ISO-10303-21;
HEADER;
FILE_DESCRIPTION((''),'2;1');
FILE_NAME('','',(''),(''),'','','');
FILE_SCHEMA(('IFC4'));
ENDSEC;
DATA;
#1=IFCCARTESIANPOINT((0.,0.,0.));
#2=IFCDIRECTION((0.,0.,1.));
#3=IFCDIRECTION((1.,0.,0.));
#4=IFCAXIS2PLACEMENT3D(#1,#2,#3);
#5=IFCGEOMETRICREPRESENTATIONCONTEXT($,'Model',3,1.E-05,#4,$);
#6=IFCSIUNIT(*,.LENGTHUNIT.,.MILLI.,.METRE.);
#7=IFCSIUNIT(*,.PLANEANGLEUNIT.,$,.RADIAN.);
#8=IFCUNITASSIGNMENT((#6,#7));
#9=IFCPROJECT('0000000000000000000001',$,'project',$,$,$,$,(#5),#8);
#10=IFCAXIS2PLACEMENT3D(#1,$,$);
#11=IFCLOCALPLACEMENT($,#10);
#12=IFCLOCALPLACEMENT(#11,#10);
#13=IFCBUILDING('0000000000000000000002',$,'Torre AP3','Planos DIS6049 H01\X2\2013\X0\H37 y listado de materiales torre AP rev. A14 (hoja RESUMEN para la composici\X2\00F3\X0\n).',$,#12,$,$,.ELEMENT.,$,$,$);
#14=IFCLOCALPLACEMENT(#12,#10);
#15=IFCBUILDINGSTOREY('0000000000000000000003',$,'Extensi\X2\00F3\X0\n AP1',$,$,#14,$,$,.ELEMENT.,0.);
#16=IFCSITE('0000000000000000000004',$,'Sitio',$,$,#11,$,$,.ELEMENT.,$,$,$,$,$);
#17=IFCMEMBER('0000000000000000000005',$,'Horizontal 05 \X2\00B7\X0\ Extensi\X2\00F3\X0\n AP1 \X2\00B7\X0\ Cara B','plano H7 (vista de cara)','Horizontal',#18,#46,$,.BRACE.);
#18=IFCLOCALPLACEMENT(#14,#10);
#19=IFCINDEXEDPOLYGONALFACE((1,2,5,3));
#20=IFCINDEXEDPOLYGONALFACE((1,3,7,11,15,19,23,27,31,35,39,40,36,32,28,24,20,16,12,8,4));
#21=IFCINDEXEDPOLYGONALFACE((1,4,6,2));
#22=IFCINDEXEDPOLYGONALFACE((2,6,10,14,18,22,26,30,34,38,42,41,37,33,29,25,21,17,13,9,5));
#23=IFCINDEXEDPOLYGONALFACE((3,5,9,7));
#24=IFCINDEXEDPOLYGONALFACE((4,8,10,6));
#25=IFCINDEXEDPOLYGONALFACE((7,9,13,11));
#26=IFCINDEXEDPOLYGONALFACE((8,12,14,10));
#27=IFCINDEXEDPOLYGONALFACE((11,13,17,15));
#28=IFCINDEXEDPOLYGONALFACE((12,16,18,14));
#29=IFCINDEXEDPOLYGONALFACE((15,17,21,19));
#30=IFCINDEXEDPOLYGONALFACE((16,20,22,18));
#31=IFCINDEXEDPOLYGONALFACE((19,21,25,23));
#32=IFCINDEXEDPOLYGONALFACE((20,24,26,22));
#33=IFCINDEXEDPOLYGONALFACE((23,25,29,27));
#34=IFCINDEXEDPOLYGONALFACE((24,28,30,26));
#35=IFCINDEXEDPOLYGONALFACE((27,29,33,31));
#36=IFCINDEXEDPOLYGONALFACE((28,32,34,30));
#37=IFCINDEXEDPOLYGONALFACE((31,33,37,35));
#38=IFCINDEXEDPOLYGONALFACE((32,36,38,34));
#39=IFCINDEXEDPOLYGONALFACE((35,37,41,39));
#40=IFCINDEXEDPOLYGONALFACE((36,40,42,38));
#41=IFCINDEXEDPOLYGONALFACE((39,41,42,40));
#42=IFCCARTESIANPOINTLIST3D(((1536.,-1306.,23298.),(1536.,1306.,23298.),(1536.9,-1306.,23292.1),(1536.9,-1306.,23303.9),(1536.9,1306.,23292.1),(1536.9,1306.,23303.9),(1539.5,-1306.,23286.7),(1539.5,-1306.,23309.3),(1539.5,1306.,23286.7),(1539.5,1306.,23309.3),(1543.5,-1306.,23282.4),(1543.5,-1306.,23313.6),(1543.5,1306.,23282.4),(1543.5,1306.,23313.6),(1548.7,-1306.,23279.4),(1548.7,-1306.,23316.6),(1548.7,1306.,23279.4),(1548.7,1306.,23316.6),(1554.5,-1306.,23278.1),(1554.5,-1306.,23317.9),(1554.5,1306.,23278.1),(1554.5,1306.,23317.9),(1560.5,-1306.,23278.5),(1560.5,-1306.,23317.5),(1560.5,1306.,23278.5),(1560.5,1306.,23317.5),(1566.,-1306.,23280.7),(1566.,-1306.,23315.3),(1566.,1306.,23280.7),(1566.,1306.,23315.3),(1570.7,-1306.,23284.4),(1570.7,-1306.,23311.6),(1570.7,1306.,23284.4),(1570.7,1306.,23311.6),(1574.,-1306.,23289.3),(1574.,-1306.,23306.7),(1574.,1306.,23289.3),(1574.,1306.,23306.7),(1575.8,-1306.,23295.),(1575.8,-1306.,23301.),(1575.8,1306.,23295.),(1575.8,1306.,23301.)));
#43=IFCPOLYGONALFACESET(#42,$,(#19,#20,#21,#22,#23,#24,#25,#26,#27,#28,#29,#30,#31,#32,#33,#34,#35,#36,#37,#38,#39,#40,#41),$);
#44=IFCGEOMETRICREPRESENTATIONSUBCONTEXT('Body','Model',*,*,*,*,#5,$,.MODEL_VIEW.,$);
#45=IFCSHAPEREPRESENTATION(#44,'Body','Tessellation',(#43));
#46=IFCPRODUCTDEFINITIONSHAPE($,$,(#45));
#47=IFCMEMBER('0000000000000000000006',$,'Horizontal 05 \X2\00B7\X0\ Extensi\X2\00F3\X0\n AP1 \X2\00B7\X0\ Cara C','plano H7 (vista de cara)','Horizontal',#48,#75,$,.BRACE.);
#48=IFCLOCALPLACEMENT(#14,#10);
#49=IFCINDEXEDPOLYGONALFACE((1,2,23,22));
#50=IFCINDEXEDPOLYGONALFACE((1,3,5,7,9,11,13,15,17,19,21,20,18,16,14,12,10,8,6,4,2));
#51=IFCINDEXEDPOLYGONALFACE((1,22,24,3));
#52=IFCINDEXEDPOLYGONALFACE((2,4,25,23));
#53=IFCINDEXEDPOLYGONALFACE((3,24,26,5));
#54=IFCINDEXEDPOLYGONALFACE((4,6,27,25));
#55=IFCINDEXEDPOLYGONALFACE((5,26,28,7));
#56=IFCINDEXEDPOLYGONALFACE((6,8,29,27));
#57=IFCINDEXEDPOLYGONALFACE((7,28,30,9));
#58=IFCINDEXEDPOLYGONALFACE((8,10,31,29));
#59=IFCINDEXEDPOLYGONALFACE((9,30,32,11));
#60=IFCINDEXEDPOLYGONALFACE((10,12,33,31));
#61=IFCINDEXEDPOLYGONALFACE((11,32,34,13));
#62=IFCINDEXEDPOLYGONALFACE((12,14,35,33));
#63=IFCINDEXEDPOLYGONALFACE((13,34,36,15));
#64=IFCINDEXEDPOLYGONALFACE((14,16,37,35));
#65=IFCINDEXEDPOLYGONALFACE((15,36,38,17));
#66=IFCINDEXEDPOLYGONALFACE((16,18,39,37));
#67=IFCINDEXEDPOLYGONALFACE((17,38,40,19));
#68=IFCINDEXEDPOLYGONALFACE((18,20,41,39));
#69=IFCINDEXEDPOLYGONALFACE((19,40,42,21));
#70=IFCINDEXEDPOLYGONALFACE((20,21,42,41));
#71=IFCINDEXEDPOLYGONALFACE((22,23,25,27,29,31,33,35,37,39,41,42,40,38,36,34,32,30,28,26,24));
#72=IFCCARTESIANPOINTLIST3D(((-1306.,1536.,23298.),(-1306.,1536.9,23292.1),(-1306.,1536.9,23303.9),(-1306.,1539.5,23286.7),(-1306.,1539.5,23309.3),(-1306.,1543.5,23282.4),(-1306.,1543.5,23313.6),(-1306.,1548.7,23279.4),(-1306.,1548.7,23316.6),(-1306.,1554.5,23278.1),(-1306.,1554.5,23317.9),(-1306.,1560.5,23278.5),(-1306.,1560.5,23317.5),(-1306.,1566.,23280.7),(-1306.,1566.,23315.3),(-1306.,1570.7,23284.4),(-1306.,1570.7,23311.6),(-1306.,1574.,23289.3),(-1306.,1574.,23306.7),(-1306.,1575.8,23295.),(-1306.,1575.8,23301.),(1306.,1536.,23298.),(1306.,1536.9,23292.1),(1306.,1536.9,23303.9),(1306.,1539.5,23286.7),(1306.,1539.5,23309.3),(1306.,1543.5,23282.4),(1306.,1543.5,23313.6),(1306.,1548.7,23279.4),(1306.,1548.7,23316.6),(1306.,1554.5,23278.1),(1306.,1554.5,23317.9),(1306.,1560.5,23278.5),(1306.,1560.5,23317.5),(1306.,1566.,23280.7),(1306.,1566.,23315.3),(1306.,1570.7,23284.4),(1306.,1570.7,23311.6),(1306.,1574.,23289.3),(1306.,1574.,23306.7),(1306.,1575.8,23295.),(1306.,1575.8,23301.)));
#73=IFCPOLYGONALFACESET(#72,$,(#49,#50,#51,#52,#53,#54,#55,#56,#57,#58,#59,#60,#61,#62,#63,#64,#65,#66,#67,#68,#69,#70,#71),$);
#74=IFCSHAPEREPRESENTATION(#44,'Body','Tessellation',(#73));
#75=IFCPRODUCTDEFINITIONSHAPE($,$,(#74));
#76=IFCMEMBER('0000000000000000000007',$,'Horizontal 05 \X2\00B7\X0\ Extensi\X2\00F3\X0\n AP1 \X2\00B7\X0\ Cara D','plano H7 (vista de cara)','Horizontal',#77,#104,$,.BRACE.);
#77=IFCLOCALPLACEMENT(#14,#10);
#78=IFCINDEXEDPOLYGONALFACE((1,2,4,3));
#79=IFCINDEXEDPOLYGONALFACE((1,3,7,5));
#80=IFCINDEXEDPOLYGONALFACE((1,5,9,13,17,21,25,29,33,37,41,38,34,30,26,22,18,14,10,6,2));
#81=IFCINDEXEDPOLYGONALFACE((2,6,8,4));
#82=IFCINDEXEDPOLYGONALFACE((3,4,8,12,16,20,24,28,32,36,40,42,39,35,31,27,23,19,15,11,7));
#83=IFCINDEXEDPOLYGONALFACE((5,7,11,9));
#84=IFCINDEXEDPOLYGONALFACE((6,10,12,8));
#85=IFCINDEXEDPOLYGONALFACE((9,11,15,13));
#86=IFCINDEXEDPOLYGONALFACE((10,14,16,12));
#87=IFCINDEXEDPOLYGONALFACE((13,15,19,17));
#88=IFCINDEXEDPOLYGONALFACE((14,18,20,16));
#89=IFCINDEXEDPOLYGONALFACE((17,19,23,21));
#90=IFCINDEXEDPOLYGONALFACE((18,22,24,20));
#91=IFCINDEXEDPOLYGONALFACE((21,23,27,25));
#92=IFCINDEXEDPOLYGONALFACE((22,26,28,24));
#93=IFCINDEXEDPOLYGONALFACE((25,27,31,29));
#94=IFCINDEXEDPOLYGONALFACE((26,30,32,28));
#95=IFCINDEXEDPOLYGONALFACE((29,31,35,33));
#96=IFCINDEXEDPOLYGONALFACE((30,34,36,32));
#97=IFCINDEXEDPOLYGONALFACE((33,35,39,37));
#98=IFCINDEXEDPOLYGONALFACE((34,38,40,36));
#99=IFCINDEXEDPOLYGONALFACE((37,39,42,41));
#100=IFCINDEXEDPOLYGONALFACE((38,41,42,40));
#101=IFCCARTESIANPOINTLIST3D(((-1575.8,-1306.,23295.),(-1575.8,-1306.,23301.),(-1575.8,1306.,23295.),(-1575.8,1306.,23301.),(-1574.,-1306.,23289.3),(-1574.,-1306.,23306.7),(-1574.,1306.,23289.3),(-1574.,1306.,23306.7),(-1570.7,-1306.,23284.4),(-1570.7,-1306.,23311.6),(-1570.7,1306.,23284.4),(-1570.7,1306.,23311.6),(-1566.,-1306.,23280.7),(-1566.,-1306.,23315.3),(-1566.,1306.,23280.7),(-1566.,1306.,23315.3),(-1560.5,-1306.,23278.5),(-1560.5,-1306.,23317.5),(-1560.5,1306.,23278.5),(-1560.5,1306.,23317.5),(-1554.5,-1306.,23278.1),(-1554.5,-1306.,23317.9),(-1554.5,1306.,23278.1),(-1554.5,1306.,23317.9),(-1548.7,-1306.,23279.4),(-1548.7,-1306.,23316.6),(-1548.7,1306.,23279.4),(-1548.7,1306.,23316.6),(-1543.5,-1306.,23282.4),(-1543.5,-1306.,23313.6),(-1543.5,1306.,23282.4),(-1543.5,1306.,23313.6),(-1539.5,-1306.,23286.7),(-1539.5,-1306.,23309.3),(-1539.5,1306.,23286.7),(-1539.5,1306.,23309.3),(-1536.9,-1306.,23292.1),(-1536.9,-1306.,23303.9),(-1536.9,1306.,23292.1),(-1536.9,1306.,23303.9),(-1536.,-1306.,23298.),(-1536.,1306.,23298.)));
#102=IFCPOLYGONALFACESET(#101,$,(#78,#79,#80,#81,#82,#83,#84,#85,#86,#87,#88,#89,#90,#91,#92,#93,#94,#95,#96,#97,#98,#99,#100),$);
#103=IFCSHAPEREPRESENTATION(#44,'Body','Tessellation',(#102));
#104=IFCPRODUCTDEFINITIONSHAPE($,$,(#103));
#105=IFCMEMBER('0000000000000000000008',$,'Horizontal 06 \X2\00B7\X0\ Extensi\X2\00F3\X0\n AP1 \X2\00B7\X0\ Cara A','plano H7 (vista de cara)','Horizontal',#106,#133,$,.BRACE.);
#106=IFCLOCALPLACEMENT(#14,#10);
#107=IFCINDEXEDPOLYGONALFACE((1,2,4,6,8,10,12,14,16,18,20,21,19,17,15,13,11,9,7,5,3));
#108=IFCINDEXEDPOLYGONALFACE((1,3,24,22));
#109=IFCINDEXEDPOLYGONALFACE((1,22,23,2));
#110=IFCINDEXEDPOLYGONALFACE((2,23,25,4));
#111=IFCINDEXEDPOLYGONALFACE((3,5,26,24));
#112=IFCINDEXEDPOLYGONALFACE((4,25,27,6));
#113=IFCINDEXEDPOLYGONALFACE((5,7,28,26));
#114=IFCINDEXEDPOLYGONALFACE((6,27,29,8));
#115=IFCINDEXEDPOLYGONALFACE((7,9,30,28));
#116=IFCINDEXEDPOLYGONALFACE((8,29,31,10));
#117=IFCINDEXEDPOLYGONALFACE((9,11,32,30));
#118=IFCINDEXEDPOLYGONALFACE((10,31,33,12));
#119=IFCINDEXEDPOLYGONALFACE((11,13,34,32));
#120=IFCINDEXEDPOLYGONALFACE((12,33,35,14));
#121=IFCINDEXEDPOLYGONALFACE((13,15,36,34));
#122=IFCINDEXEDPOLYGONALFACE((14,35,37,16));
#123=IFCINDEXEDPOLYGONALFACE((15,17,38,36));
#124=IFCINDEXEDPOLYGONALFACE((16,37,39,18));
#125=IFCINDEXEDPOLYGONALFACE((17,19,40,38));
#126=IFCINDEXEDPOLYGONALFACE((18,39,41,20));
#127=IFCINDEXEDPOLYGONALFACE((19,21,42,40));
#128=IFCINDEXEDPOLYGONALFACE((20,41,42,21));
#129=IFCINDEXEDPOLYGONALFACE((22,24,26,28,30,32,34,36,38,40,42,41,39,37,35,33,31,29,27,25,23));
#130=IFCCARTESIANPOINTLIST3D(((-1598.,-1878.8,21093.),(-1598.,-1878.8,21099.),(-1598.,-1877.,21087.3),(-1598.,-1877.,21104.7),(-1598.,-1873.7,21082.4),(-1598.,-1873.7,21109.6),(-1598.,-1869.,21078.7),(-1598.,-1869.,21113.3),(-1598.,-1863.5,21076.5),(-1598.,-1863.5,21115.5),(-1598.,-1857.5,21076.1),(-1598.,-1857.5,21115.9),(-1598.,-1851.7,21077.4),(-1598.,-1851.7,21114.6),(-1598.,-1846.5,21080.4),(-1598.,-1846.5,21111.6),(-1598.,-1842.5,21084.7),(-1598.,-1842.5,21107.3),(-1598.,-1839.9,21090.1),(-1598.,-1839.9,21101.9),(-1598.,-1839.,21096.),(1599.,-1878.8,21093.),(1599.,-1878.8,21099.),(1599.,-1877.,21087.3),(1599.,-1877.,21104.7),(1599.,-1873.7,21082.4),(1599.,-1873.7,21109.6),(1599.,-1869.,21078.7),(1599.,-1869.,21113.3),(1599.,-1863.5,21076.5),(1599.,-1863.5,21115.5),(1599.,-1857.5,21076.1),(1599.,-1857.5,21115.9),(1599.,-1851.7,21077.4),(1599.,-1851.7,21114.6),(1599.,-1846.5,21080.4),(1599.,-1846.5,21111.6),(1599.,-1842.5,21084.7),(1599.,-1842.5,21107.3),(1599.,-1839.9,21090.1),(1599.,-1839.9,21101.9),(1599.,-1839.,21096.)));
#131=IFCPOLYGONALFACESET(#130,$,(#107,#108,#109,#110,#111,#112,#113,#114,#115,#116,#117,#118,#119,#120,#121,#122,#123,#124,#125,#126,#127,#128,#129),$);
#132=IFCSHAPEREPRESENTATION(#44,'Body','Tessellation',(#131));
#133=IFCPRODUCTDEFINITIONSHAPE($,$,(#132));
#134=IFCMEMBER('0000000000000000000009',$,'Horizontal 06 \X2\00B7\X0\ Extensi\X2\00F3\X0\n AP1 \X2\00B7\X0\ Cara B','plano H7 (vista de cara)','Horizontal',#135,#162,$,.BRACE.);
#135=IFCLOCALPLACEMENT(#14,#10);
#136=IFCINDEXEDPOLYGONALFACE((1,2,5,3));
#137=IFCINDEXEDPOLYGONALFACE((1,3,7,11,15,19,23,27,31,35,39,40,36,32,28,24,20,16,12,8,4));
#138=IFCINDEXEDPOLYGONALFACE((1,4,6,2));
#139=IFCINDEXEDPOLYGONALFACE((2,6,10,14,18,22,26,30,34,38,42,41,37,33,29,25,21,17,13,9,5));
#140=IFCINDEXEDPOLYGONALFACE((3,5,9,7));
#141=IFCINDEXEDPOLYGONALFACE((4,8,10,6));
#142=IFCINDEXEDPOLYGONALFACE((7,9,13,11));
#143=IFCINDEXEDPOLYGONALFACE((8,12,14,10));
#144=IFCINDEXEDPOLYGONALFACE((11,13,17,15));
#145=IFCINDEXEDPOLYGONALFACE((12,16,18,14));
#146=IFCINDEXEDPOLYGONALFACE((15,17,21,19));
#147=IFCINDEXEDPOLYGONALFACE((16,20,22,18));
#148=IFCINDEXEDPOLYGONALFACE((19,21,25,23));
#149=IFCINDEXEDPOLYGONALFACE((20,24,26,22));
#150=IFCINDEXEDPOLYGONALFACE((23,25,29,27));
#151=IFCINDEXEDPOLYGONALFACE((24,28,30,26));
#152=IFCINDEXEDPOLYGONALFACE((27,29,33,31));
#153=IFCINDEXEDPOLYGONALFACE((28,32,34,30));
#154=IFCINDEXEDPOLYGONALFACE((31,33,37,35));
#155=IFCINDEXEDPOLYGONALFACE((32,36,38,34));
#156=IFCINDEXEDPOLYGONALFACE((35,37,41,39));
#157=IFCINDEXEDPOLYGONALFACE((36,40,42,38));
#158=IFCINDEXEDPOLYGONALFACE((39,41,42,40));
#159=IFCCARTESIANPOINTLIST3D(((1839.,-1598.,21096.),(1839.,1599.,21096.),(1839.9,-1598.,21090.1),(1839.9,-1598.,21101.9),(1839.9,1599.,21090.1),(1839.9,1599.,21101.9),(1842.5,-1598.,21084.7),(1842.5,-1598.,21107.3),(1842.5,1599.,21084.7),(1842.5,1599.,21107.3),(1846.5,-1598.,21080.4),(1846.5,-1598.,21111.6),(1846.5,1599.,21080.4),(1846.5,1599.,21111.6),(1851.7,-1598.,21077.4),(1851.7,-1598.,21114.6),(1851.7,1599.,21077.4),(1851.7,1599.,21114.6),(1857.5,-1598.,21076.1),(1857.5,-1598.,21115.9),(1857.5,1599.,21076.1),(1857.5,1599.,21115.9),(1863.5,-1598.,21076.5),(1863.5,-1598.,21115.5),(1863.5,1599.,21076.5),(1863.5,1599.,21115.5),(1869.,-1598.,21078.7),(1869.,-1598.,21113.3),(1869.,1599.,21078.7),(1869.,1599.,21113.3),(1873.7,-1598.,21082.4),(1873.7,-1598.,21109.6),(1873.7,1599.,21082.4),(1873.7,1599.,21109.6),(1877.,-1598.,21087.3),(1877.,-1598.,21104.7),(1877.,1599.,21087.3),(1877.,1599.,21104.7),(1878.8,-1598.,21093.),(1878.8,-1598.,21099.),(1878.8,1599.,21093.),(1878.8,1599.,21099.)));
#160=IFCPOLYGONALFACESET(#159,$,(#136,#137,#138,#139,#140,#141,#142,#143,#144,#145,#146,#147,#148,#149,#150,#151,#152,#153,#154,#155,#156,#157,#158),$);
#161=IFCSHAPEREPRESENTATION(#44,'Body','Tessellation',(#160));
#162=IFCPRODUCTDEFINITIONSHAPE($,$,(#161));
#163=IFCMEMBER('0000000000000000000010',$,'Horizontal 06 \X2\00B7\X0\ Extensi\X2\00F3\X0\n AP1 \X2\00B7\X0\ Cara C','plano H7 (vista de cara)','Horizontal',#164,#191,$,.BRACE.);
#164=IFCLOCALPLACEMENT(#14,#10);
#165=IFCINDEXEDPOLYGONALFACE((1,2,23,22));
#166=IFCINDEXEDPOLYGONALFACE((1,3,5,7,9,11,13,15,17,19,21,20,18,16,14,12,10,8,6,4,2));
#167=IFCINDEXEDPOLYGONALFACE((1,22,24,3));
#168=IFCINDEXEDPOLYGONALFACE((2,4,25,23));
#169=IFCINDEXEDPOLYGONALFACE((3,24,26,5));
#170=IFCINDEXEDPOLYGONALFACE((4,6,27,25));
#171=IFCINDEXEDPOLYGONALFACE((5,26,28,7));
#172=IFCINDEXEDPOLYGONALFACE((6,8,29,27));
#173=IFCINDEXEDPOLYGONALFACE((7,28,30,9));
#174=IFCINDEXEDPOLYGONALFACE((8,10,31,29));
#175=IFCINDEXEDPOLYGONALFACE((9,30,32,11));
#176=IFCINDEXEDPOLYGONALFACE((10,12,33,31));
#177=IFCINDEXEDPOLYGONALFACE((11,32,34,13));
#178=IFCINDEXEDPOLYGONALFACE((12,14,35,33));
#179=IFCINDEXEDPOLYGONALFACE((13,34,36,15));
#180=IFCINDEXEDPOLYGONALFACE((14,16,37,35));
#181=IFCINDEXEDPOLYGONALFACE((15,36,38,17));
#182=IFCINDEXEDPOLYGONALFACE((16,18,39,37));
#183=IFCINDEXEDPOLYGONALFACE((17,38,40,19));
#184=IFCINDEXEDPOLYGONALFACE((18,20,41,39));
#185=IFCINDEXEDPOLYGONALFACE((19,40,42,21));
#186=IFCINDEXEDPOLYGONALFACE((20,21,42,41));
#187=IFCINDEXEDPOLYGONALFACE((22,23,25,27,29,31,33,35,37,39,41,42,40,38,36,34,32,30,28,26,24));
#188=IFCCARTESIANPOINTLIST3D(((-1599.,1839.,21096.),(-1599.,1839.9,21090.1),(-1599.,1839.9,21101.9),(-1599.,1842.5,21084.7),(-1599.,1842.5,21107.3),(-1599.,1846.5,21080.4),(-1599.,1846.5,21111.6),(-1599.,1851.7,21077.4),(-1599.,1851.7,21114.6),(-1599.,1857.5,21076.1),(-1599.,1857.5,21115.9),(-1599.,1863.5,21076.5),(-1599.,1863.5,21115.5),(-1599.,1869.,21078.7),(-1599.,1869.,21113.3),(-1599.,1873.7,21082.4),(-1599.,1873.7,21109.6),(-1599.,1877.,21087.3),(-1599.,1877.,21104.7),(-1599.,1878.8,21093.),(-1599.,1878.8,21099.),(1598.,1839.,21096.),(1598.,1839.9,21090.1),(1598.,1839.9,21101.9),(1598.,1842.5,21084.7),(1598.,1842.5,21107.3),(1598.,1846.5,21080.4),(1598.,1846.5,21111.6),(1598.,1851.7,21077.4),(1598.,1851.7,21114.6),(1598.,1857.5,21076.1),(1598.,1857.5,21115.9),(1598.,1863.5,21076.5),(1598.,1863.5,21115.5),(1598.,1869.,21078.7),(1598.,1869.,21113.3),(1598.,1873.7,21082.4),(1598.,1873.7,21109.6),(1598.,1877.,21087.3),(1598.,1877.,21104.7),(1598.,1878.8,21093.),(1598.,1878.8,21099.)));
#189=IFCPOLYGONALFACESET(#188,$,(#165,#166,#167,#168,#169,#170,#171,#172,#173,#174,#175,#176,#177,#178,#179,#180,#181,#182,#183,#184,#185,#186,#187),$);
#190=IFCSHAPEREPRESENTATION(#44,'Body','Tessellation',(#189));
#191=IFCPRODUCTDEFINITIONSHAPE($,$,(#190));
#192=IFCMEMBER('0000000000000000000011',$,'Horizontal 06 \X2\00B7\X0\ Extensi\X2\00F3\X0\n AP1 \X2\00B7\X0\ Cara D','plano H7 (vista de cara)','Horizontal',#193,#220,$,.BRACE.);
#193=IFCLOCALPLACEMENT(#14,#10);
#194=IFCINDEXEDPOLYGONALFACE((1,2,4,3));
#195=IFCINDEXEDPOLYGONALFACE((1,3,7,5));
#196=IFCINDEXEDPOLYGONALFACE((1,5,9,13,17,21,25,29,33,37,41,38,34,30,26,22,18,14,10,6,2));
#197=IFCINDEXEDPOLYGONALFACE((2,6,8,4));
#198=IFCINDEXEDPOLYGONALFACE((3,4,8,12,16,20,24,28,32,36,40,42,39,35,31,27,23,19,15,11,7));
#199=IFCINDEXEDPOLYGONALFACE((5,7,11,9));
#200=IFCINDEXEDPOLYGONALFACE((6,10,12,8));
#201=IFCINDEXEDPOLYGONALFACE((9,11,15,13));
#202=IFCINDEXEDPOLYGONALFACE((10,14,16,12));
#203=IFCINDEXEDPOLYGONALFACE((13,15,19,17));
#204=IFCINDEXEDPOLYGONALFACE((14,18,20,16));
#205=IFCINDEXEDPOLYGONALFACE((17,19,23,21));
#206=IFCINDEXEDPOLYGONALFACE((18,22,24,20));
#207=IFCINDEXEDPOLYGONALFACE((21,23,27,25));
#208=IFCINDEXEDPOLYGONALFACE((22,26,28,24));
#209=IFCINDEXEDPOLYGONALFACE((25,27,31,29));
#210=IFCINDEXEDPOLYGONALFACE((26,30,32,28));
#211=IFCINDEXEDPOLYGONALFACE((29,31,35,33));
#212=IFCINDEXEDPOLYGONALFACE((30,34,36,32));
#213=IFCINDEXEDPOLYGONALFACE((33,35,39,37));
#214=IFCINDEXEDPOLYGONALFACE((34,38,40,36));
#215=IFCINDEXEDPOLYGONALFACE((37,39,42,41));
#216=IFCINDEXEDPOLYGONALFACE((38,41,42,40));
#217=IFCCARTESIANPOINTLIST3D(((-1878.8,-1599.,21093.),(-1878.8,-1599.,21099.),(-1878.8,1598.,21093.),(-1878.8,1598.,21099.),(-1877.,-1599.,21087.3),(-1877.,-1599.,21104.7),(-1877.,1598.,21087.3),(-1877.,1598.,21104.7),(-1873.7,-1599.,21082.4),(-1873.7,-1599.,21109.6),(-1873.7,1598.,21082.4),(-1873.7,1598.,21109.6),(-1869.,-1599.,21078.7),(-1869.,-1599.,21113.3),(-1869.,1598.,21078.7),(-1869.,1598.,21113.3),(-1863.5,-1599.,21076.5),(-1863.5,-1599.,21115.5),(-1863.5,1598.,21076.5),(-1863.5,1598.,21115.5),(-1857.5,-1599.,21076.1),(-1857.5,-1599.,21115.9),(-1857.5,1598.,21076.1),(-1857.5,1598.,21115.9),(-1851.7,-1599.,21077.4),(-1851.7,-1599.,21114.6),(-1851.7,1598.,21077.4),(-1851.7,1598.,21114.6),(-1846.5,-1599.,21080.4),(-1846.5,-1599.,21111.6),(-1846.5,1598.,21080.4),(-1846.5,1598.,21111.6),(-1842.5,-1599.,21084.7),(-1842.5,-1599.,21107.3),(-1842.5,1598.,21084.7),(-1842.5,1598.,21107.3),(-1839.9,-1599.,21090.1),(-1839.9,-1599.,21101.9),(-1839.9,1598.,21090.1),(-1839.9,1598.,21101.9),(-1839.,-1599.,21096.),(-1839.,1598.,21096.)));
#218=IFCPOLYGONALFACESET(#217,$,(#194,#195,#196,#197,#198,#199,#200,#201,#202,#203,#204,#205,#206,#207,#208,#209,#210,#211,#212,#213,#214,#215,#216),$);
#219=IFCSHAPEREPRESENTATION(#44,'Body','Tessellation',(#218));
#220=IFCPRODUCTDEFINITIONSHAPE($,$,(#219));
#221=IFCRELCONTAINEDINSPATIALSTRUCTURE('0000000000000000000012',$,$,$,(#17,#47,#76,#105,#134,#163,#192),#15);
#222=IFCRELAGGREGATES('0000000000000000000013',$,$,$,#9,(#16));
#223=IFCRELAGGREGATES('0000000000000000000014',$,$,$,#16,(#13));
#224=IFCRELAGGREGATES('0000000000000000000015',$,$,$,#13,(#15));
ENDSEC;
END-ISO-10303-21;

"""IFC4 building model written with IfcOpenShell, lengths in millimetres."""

from ifc_helpers import new_model, si_unit, frame, origin, origin_with_axes, place, context, subcontext, project, spatial, circle, extrude, element, save


model = new_model("IFC4")

# Units and contexts
model_context = context("Model", 3, precision=1e-05, world=origin_with_axes())
body_context = subcontext(model_context, "Body", "Model", "MODEL_VIEW")
ifc_project = project(units=[si_unit("LENGTHUNIT", "METRE", prefix="MILLI"), si_unit("PLANEANGLEUNIT", "RADIAN")], contexts=[model_context])

# Site, building, storey
site_placement = place(None, origin())
site = spatial("IfcSite", under=ifc_project, at=site_placement, Name="Sitio", CompositionType="ELEMENT")
building_placement = place(site_placement, origin())
building = spatial("IfcBuilding", under=site, at=building_placement, Name="Torre AP3", Description="Planos DIS6049 H01–H37 y listado de materiales torre AP rev. A14 (hoja RESUMEN para la composición).", CompositionType="ELEMENT")
storey_placement = place(building_placement, origin())
storey = spatial("IfcBuildingStorey", under=building, at=storey_placement, Name="Extensión AP1", CompositionType="ELEMENT", Elevation=0.0)

# Members
for number, where, z_axis, x_axis, name in (
    (1, (1556.0, 1306.0, 23298.0), (0.0, -1.0, 0.0), (-1.0, 0.0, 0.0), "Horizontal 05 · Extensión AP1 · Cara B"),
    (2, (-1306.0, 1556.0, 23298.0), (1.0, 0.0, 0.0), (0.0, -1.0, 0.0), "Horizontal 05 · Extensión AP1 · Cara C"),
    (3, (-1556.0, -1306.0, 23298.0), (0.0, 1.0, 0.0), (1.0, 0.0, 0.0), "Horizontal 05 · Extensión AP1 · Cara D"),
):
    element("IfcMember", number, at=place(storey_placement, frame(where, z_axis=z_axis, x_axis=x_axis)), inside=storey, Name=name, Description="plano H7 (vista de cara)", ObjectType="Horizontal", PredefinedType="BRACE", context=body_context, shape_type="SweptSolid", body=[
        extrude(circle(Radius=20.0), None, (0.0, 0.0, 1.0), 2612.0),
    ])
for number, where, z_axis, x_axis, name in (
    (4, (1599.0, -1859.0, 21096.0), (-1.0, 0.0, 0.0), (0.0, 1.0, 0.0), "Horizontal 06 · Extensión AP1 · Cara A"),
    (5, (1859.0, 1599.0, 21096.0), (0.0, -1.0, 0.0), (-1.0, 0.0, 0.0), "Horizontal 06 · Extensión AP1 · Cara B"),
    (6, (-1599.0, 1859.0, 21096.0), (1.0, 0.0, 0.0), (0.0, -1.0, 0.0), "Horizontal 06 · Extensión AP1 · Cara C"),
    (7, (-1859.0, -1599.0, 21096.0), (0.0, 1.0, 0.0), (1.0, 0.0, 0.0), "Horizontal 06 · Extensión AP1 · Cara D"),
):
    element("IfcMember", number, at=place(storey_placement, frame(where, z_axis=z_axis, x_axis=x_axis)), inside=storey, Name=name, Description="plano H7 (vista de cara)", ObjectType="Horizontal", PredefinedType="BRACE", context=body_context, shape_type="SweptSolid", body=[
        extrude(circle(Radius=20.0), None, (0.0, 0.0, 1.0), 3197.0),
    ])

save(model, "model.ifc")
